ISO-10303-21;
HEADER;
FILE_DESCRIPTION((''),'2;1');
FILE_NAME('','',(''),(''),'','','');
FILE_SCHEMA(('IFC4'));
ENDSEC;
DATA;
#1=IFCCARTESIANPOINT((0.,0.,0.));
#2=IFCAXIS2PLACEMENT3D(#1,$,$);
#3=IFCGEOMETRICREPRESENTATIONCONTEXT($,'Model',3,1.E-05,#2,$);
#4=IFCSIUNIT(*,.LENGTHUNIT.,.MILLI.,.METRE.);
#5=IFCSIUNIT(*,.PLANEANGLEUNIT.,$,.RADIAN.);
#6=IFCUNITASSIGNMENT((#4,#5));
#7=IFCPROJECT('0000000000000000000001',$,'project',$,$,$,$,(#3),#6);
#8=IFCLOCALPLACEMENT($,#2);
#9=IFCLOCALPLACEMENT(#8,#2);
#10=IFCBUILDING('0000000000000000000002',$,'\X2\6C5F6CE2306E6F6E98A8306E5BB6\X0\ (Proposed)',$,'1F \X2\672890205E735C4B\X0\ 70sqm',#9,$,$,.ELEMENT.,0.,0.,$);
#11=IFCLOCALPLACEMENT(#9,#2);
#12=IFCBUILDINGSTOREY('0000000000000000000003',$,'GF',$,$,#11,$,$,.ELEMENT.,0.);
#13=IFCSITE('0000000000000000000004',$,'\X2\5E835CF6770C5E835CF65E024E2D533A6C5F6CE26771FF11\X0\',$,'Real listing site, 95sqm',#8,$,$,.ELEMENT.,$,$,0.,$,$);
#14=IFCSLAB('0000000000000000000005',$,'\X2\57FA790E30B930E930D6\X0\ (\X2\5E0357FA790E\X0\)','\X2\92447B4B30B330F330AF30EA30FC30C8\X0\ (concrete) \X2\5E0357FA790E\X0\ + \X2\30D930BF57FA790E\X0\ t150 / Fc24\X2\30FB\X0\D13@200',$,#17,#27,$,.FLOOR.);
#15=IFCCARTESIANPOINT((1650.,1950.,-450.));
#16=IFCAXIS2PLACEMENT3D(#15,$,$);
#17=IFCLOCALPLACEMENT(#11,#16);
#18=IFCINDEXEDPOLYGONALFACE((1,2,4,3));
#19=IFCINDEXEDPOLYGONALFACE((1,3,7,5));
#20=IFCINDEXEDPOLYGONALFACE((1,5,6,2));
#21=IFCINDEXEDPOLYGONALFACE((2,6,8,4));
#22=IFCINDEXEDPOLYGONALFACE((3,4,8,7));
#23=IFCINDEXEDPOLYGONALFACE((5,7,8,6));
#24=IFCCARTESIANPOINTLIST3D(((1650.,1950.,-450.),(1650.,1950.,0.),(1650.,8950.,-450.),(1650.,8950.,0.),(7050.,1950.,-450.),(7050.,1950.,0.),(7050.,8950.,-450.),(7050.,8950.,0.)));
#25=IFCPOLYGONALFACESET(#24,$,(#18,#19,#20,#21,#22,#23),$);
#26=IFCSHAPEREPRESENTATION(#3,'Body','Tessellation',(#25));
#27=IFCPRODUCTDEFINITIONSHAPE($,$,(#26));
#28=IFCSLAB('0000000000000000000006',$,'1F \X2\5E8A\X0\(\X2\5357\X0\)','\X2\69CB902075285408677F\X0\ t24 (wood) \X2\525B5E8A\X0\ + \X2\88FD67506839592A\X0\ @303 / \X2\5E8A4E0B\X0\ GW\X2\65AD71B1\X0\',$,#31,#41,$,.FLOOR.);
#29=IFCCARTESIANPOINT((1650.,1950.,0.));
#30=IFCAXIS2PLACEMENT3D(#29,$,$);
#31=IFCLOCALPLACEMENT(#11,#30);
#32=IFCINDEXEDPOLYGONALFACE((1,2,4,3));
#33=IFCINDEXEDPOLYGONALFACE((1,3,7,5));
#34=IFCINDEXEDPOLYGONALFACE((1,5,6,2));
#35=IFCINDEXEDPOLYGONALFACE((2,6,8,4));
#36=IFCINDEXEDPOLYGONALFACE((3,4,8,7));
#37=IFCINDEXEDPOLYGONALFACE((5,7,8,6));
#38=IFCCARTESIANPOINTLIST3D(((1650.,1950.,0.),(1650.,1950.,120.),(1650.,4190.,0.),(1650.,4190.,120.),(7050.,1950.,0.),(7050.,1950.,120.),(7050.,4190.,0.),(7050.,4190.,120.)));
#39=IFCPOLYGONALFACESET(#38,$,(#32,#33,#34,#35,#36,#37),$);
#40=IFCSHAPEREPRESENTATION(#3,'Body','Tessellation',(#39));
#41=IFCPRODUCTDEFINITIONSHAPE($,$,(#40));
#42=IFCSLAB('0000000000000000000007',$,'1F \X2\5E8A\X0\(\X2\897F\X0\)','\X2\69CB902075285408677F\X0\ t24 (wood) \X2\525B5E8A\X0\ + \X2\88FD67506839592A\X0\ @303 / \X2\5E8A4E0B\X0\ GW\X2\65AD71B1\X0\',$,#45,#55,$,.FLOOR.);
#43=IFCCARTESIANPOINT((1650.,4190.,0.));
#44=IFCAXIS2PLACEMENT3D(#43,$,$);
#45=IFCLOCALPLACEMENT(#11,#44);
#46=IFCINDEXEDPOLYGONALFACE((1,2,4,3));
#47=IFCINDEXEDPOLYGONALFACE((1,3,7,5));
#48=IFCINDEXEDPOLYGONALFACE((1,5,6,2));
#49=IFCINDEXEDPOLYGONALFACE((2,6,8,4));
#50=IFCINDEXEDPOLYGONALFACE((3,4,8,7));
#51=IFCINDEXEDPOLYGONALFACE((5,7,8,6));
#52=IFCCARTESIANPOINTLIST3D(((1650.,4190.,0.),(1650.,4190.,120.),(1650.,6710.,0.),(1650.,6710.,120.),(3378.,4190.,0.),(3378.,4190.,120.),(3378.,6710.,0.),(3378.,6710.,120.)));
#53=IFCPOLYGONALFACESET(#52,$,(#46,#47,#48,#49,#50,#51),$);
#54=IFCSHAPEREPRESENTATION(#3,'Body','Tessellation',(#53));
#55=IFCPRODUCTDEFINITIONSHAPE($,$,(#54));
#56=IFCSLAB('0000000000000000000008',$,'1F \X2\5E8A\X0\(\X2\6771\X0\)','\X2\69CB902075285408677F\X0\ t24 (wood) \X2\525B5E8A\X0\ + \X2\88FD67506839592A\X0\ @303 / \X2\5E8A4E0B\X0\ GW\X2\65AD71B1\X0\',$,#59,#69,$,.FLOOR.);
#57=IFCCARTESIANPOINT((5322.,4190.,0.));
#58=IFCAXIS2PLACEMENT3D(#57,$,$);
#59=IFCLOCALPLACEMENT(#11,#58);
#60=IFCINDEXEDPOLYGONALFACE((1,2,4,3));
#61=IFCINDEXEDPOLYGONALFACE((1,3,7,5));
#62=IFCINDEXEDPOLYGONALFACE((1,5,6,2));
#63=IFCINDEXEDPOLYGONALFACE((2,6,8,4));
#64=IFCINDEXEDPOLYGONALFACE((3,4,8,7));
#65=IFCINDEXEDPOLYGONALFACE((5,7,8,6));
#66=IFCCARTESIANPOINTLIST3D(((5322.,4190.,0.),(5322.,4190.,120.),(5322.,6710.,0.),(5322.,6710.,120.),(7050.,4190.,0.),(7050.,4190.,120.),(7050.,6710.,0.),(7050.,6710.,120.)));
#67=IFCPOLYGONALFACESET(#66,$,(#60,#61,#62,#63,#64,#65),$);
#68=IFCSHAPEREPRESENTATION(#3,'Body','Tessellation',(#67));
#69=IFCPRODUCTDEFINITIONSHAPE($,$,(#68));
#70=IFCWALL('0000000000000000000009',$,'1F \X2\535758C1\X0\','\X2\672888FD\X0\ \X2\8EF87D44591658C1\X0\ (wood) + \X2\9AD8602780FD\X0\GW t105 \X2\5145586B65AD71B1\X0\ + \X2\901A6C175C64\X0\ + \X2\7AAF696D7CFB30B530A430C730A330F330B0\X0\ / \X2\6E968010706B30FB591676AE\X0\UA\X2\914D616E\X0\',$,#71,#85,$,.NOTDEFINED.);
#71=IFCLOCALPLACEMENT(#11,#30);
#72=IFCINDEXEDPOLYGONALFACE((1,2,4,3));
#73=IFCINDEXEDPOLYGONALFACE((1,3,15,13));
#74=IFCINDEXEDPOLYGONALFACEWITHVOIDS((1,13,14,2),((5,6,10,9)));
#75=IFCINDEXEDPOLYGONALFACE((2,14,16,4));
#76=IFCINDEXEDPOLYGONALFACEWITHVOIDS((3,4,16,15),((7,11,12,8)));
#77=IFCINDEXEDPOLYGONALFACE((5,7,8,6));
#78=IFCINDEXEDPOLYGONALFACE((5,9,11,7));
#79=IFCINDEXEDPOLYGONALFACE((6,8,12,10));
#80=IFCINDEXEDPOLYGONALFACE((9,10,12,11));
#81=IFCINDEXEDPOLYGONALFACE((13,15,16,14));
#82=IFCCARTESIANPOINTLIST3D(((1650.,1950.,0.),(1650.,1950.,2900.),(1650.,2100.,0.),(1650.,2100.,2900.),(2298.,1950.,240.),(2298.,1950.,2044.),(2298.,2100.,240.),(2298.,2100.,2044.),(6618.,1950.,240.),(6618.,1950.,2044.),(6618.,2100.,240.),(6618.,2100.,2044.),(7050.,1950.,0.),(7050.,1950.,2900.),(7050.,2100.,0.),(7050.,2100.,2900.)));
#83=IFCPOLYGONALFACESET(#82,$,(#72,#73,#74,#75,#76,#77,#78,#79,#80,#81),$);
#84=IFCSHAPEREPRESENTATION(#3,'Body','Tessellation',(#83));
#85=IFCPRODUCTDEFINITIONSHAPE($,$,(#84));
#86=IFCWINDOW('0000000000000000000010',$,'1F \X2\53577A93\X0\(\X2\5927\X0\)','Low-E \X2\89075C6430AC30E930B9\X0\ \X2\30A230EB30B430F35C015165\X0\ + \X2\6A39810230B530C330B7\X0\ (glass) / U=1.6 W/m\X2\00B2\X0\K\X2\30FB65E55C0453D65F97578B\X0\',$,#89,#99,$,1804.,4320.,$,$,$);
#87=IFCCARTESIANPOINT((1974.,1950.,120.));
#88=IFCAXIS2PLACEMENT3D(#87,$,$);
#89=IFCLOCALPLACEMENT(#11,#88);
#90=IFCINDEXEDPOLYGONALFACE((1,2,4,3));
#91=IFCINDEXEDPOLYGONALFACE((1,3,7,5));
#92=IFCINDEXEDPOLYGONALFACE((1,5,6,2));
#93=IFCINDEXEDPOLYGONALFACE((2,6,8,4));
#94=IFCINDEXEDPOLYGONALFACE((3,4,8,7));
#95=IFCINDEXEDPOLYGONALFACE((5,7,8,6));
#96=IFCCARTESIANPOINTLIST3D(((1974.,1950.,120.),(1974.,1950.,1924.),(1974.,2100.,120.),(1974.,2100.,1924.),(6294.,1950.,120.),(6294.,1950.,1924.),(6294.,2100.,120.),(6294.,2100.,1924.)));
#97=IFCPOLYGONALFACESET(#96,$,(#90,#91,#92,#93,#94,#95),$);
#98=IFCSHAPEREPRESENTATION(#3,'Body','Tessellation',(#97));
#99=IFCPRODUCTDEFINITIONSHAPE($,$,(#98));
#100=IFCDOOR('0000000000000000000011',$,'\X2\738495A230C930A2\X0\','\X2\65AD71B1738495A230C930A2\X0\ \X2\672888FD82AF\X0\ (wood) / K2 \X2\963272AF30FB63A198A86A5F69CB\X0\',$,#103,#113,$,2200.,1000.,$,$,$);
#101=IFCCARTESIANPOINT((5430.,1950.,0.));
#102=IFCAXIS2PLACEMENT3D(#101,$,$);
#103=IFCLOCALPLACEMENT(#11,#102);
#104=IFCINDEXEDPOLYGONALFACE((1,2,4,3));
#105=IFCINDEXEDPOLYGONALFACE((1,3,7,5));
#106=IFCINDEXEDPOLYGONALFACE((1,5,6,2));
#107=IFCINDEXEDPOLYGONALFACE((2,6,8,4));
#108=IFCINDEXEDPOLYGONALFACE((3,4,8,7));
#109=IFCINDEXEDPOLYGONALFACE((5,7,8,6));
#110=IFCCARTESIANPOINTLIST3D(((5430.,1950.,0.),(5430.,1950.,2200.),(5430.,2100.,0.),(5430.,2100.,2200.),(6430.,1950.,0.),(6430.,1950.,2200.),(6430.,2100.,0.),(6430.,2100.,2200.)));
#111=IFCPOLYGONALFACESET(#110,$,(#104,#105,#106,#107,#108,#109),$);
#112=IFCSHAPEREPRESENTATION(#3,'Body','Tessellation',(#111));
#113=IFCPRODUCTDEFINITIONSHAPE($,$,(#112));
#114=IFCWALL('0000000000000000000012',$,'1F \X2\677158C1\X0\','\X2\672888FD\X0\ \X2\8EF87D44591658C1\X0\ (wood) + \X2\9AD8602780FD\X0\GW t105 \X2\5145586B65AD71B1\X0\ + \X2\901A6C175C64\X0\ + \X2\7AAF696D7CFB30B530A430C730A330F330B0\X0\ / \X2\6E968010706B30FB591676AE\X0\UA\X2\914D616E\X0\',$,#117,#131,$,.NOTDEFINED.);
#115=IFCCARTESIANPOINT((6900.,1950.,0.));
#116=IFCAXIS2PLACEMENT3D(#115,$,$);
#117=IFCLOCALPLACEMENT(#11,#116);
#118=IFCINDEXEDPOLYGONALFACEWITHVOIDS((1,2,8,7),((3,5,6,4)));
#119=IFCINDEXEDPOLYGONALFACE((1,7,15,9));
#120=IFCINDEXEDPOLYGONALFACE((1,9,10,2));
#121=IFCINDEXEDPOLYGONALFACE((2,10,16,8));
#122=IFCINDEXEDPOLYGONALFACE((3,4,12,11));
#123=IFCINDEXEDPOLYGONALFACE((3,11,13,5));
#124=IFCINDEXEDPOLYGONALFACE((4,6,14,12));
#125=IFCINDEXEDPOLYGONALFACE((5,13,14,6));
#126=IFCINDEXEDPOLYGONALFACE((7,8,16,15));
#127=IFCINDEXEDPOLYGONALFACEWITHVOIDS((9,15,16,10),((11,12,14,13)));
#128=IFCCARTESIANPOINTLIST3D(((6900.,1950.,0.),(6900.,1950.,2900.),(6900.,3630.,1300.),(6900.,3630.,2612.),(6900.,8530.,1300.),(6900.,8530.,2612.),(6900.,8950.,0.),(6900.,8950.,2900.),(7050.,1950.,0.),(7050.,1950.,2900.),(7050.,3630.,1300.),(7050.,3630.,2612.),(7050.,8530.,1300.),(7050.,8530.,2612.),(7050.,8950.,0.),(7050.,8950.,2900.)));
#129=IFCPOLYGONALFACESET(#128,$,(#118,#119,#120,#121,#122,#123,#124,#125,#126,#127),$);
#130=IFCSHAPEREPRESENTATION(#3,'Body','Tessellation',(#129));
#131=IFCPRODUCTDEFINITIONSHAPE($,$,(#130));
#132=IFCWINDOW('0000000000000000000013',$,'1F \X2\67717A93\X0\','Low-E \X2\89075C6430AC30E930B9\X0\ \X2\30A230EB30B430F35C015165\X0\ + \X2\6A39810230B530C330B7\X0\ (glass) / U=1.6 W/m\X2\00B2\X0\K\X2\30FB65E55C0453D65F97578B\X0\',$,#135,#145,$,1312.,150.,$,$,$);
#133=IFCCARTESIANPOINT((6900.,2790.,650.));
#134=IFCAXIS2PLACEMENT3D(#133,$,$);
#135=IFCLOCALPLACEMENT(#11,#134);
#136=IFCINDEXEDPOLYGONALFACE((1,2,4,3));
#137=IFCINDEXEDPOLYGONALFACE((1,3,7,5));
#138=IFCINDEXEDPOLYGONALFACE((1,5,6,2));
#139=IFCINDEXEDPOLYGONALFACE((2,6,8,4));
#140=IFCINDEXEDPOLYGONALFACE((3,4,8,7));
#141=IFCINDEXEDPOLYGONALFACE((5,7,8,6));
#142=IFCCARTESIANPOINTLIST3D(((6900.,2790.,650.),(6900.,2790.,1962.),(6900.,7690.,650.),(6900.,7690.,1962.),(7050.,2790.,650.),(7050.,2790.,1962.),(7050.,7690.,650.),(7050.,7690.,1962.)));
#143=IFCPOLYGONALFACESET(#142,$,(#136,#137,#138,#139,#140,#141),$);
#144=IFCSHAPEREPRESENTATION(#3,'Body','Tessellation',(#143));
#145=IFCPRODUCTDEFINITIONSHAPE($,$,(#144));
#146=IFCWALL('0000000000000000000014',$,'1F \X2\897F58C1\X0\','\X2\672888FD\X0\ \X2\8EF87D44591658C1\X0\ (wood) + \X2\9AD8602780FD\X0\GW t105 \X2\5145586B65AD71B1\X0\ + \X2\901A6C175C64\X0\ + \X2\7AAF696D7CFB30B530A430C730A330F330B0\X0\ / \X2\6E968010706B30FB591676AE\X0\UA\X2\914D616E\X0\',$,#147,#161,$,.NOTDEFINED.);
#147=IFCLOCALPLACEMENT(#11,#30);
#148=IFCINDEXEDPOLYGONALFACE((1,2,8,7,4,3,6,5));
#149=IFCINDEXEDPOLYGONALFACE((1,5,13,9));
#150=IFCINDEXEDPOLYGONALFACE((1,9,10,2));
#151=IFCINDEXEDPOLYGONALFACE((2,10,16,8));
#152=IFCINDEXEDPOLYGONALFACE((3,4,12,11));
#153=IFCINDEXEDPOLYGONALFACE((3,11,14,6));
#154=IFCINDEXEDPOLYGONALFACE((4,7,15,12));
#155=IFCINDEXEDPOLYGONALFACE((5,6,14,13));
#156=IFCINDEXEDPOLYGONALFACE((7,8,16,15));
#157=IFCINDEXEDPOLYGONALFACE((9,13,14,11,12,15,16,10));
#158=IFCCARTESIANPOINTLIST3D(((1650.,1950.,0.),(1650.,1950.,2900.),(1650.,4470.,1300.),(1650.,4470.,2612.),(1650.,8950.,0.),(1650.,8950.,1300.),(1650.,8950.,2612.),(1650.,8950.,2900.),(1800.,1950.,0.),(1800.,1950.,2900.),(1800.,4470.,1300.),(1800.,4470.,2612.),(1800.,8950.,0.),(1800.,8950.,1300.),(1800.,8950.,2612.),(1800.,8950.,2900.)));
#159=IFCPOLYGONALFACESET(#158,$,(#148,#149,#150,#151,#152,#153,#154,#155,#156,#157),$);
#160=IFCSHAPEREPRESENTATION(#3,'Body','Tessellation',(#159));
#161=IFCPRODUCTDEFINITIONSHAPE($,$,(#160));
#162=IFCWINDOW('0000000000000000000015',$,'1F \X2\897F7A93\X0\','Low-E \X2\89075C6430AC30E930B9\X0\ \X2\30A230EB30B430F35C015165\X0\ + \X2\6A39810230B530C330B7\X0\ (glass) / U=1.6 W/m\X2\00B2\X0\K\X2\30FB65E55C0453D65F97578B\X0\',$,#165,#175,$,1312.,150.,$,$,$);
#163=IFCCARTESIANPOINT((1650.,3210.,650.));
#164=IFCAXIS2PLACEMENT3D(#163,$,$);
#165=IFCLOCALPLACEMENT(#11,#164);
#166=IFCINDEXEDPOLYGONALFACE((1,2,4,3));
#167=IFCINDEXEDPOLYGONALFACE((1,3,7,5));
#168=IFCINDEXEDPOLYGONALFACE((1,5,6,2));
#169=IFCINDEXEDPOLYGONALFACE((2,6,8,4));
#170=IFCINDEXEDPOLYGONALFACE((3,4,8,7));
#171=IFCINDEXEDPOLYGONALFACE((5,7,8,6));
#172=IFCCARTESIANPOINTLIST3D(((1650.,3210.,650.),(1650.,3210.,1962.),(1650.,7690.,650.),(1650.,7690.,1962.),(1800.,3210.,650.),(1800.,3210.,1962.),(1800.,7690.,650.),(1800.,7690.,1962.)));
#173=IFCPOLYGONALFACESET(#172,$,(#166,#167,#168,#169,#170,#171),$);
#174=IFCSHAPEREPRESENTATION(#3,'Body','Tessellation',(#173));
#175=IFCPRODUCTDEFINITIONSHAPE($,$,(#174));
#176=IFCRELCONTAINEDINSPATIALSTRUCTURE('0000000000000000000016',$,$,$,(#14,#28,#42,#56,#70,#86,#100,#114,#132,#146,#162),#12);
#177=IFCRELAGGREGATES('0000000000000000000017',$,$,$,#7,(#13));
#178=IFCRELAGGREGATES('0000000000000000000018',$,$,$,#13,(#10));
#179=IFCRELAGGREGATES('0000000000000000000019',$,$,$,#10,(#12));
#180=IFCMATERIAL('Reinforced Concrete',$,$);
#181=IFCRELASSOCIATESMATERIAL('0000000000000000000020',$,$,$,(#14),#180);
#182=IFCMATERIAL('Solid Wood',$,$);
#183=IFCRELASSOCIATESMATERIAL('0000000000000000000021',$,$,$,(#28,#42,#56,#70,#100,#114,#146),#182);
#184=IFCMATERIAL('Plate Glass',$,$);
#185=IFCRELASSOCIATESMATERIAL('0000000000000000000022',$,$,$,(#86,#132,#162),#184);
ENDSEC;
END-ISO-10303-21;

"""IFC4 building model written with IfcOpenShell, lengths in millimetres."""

from ifc_helpers import new_model, si_unit, frame, frame_2d, origin, place, context, project, spatial, rectangle, extrude, material, element, fill, save


model = new_model("IFC4")

# Units and contexts
model_context = context("Model", 3, precision=1e-05, world=origin())
ifc_project = project(units=[si_unit("LENGTHUNIT", "METRE", prefix="MILLI"), si_unit("PLANEANGLEUNIT", "RADIAN")], contexts=[model_context])

# Site, building, storey
site_placement = place(None, origin())
site = spatial("IfcSite", under=ifc_project, at=site_placement, Name="広島県広島市中区江波東１", ObjectType="Real listing site, 95sqm", CompositionType="ELEMENT", RefElevation=0.0)
building_placement = place(site_placement, origin())
building = spatial("IfcBuilding", under=site, at=building_placement, Name="江波の潮風の家 (Proposed)", ObjectType="1F 木造平屋 70sqm", CompositionType="ELEMENT", ElevationOfRefHeight=0.0, ElevationOfTerrain=0.0)
storey_placement = place(building_placement, origin())
storey = spatial("IfcBuildingStorey", under=building, at=storey_placement, Name="GF", CompositionType="ELEMENT", Elevation=0.0)

# Slabs
ifc_material_1 = material(Name="Reinforced Concrete")
slab_1_placement = place(storey_placement, frame((1650.0, 1950.0, -450.0)))
element("IfcSlab", 1, at=slab_1_placement, inside=storey, material=ifc_material_1, Name="基礎スラブ (布基礎)", Description="鉄筋コンクリート (concrete) 布基礎 + ベタ基礎 t150 / Fc24・D13@200", PredefinedType="FLOOR", context=model_context, shape_type="SweptSolid", body=[
    extrude(rectangle(XDim=5400.0, YDim=7000.0, at=frame_2d((2700.0, 3500.0))), frame((1650.0, 1950.0, -450.0)), (0.0, 0.0, 1.0), 450.0),
])
ifc_material_2 = material(Name="Solid Wood")
slab_2_placement = place(storey_placement, frame((1650.0, 1950.0, 0.0)))
element("IfcSlab", 2, at=slab_2_placement, inside=storey, material=ifc_material_2, Name="1F 床(南)", Description="構造用合板 t24 (wood) 剛床 + 製材根太 @303 / 床下 GW断熱", PredefinedType="FLOOR", context=model_context, shape_type="SweptSolid", body=[
    extrude(rectangle(XDim=5400.0, YDim=2240.0, at=frame_2d((2700.0, 1120.0))), frame((1650.0, 1950.0, 0.0)), (0.0, 0.0, 1.0), 120.0),
])
slab_3_placement = place(storey_placement, frame((1650.0, 4190.0, 0.0)))
element("IfcSlab", 3, at=slab_3_placement, inside=storey, material=ifc_material_2, Name="1F 床(西)", Description="構造用合板 t24 (wood) 剛床 + 製材根太 @303 / 床下 GW断熱", PredefinedType="FLOOR", context=model_context, shape_type="SweptSolid", body=[
    extrude(rectangle(XDim=1728.0, YDim=2520.0, at=frame_2d((864.0, 1260.0))), frame((1650.0, 4190.0, 0.0)), (0.0, 0.0, 1.0), 120.0),
])
slab_4_placement = place(storey_placement, frame((5322.0, 4190.0, 0.0)))
element("IfcSlab", 4, at=slab_4_placement, inside=storey, material=ifc_material_2, Name="1F 床(東)", Description="構造用合板 t24 (wood) 剛床 + 製材根太 @303 / 床下 GW断熱", PredefinedType="FLOOR", context=model_context, shape_type="SweptSolid", body=[
    extrude(rectangle(XDim=1728.0, YDim=2520.0, at=frame_2d((864.0, 1260.0))), frame((5322.0, 4190.0, 0.0)), (0.0, 0.0, 1.0), 120.0),
])

# Wall, openings, window, door
wall_1_placement = place(storey_placement, frame((1650.0, 1950.0, 0.0)))
wall_1 = element("IfcWall", 5, at=wall_1_placement, inside=storey, material=ifc_material_2, Name="1F 南壁", Description="木製 軸組外壁 (wood) + 高性能GW t105 充填断熱 + 通気層 + 窯業系サイディング / 準耐火・外皮UA配慮", PredefinedType="NOTDEFINED", context=model_context, shape_type="SweptSolid", body=[
    extrude(rectangle(XDim=5400.0, YDim=150.0, at=frame_2d((2700.0, 75.0))), frame((1650.0, 1950.0, 0.0)), (0.0, 0.0, 1.0), 2900.0),
])
opening_1_placement = place(storey_placement, frame((1974.0, 1950.0, 120.0)))
opening_1 = element("IfcOpeningElement", 6, at=opening_1_placement, cuts=wall_1, PredefinedType="NOTDEFINED", context=model_context, shape_type="SweptSolid", body=[
    extrude(rectangle(XDim=4320.0, YDim=150.0, at=frame_2d((2160.0, 75.0))), frame((1974.0, 1950.0, 120.0)), (0.0, 0.0, 1.0), 1804.0),
])
opening_2_placement = place(storey_placement, frame((5430.0, 1950.0, 0.0)))
opening_2 = element("IfcOpeningElement", 7, at=opening_2_placement, cuts=wall_1, PredefinedType="NOTDEFINED", context=model_context, shape_type="SweptSolid", body=[
    extrude(rectangle(XDim=1000.0, YDim=150.0, at=frame_2d((500.0, 75.0))), frame((5430.0, 1950.0, 0.0)), (0.0, 0.0, 1.0), 2200.0),
])
ifc_material_3 = material(Name="Plate Glass")
window_1_placement = place(storey_placement, frame((1974.0, 1950.0, 120.0)))
window_1 = element("IfcWindow", 8, at=window_1_placement, inside=storey, material=ifc_material_3, Name="1F 南窓(大)", Description="Low-E 複層ガラス アルゴン封入 + 樹脂サッシ (glass) / U=1.6 W/m²K・日射取得型", OverallHeight=1804.0, OverallWidth=4320.0, context=model_context, shape_type="SweptSolid", body=[
    extrude(rectangle(XDim=4320.0, YDim=150.0, at=frame_2d((2160.0, 75.0))), frame((1974.0, 1950.0, 120.0)), (0.0, 0.0, 1.0), 1804.0),
])
fill(opening_1, window_1)
door_placement = place(storey_placement, frame((5430.0, 1950.0, 0.0)))
door = element("IfcDoor", 9, at=door_placement, inside=storey, material=ifc_material_2, Name="玄関ドア", Description="断熱玄関ドア 木製芯 (wood) / K2 防犯・採風機構", OverallHeight=2200.0, OverallWidth=1000.0, context=model_context, shape_type="SweptSolid", body=[
    extrude(rectangle(XDim=1000.0, YDim=150.0, at=frame_2d((500.0, 75.0))), frame((5430.0, 1950.0, 0.0)), (0.0, 0.0, 1.0), 2200.0),
])
fill(opening_2, door)

# Walls, openings, windows
wall_2_placement = place(storey_placement, frame((6900.0, 1950.0, 0.0)))
wall_2 = element("IfcWall", 10, at=wall_2_placement, inside=storey, material=ifc_material_2, Name="1F 東壁", Description="木製 軸組外壁 (wood) + 高性能GW t105 充填断熱 + 通気層 + 窯業系サイディング / 準耐火・外皮UA配慮", PredefinedType="NOTDEFINED", context=model_context, shape_type="SweptSolid", body=[
    extrude(rectangle(XDim=150.0, YDim=7000.0, at=frame_2d((75.0, 3500.0))), frame((6900.0, 1950.0, 0.0)), (0.0, 0.0, 1.0), 2900.0),
])
opening_3_placement = place(storey_placement, frame((6900.0, 2790.0, 650.0)))
opening_3 = element("IfcOpeningElement", 11, at=opening_3_placement, cuts=wall_2, PredefinedType="NOTDEFINED", context=model_context, shape_type="SweptSolid", body=[
    extrude(rectangle(XDim=150.0, YDim=4900.0, at=frame_2d((75.0, 2450.0))), frame((6900.0, 2790.0, 650.0)), (0.0, 0.0, 1.0), 1312.0),
])
window_2_placement = place(storey_placement, frame((6900.0, 2790.0, 650.0)))
window_2 = element("IfcWindow", 12, at=window_2_placement, inside=storey, material=ifc_material_3, Name="1F 東窓", Description="Low-E 複層ガラス アルゴン封入 + 樹脂サッシ (glass) / U=1.6 W/m²K・日射取得型", OverallHeight=1312.0, OverallWidth=150.0, context=model_context, shape_type="SweptSolid", body=[
    extrude(rectangle(XDim=150.0, YDim=4900.0, at=frame_2d((75.0, 2450.0))), frame((6900.0, 2790.0, 650.0)), (0.0, 0.0, 1.0), 1312.0),
])
fill(opening_3, window_2)
wall_3_placement = place(storey_placement, frame((1650.0, 1950.0, 0.0)))
wall_3 = element("IfcWall", 13, at=wall_3_placement, inside=storey, material=ifc_material_2, Name="1F 西壁", Description="木製 軸組外壁 (wood) + 高性能GW t105 充填断熱 + 通気層 + 窯業系サイディング / 準耐火・外皮UA配慮", PredefinedType="NOTDEFINED", context=model_context, shape_type="SweptSolid", body=[
    extrude(rectangle(XDim=150.0, YDim=7000.0, at=frame_2d((75.0, 3500.0))), frame((1650.0, 1950.0, 0.0)), (0.0, 0.0, 1.0), 2900.0),
])
opening_4_placement = place(storey_placement, frame((1650.0, 3210.0, 650.0)))
opening_4 = element("IfcOpeningElement", 14, at=opening_4_placement, cuts=wall_3, PredefinedType="NOTDEFINED", context=model_context, shape_type="SweptSolid", body=[
    extrude(rectangle(XDim=150.0, YDim=4480.0, at=frame_2d((75.0, 2240.0))), frame((1650.0, 3210.0, 650.0)), (0.0, 0.0, 1.0), 1312.0),
])
window_3_placement = place(storey_placement, frame((1650.0, 3210.0, 650.0)))
window_3 = element("IfcWindow", 15, at=window_3_placement, inside=storey, material=ifc_material_3, Name="1F 西窓", Description="Low-E 複層ガラス アルゴン封入 + 樹脂サッシ (glass) / U=1.6 W/m²K・日射取得型", OverallHeight=1312.0, OverallWidth=150.0, context=model_context, shape_type="SweptSolid", body=[
    extrude(rectangle(XDim=150.0, YDim=4480.0, at=frame_2d((75.0, 2240.0))), frame((1650.0, 3210.0, 650.0)), (0.0, 0.0, 1.0), 1312.0),
])
fill(opening_4, window_3)

save(model, "model.ifc")
